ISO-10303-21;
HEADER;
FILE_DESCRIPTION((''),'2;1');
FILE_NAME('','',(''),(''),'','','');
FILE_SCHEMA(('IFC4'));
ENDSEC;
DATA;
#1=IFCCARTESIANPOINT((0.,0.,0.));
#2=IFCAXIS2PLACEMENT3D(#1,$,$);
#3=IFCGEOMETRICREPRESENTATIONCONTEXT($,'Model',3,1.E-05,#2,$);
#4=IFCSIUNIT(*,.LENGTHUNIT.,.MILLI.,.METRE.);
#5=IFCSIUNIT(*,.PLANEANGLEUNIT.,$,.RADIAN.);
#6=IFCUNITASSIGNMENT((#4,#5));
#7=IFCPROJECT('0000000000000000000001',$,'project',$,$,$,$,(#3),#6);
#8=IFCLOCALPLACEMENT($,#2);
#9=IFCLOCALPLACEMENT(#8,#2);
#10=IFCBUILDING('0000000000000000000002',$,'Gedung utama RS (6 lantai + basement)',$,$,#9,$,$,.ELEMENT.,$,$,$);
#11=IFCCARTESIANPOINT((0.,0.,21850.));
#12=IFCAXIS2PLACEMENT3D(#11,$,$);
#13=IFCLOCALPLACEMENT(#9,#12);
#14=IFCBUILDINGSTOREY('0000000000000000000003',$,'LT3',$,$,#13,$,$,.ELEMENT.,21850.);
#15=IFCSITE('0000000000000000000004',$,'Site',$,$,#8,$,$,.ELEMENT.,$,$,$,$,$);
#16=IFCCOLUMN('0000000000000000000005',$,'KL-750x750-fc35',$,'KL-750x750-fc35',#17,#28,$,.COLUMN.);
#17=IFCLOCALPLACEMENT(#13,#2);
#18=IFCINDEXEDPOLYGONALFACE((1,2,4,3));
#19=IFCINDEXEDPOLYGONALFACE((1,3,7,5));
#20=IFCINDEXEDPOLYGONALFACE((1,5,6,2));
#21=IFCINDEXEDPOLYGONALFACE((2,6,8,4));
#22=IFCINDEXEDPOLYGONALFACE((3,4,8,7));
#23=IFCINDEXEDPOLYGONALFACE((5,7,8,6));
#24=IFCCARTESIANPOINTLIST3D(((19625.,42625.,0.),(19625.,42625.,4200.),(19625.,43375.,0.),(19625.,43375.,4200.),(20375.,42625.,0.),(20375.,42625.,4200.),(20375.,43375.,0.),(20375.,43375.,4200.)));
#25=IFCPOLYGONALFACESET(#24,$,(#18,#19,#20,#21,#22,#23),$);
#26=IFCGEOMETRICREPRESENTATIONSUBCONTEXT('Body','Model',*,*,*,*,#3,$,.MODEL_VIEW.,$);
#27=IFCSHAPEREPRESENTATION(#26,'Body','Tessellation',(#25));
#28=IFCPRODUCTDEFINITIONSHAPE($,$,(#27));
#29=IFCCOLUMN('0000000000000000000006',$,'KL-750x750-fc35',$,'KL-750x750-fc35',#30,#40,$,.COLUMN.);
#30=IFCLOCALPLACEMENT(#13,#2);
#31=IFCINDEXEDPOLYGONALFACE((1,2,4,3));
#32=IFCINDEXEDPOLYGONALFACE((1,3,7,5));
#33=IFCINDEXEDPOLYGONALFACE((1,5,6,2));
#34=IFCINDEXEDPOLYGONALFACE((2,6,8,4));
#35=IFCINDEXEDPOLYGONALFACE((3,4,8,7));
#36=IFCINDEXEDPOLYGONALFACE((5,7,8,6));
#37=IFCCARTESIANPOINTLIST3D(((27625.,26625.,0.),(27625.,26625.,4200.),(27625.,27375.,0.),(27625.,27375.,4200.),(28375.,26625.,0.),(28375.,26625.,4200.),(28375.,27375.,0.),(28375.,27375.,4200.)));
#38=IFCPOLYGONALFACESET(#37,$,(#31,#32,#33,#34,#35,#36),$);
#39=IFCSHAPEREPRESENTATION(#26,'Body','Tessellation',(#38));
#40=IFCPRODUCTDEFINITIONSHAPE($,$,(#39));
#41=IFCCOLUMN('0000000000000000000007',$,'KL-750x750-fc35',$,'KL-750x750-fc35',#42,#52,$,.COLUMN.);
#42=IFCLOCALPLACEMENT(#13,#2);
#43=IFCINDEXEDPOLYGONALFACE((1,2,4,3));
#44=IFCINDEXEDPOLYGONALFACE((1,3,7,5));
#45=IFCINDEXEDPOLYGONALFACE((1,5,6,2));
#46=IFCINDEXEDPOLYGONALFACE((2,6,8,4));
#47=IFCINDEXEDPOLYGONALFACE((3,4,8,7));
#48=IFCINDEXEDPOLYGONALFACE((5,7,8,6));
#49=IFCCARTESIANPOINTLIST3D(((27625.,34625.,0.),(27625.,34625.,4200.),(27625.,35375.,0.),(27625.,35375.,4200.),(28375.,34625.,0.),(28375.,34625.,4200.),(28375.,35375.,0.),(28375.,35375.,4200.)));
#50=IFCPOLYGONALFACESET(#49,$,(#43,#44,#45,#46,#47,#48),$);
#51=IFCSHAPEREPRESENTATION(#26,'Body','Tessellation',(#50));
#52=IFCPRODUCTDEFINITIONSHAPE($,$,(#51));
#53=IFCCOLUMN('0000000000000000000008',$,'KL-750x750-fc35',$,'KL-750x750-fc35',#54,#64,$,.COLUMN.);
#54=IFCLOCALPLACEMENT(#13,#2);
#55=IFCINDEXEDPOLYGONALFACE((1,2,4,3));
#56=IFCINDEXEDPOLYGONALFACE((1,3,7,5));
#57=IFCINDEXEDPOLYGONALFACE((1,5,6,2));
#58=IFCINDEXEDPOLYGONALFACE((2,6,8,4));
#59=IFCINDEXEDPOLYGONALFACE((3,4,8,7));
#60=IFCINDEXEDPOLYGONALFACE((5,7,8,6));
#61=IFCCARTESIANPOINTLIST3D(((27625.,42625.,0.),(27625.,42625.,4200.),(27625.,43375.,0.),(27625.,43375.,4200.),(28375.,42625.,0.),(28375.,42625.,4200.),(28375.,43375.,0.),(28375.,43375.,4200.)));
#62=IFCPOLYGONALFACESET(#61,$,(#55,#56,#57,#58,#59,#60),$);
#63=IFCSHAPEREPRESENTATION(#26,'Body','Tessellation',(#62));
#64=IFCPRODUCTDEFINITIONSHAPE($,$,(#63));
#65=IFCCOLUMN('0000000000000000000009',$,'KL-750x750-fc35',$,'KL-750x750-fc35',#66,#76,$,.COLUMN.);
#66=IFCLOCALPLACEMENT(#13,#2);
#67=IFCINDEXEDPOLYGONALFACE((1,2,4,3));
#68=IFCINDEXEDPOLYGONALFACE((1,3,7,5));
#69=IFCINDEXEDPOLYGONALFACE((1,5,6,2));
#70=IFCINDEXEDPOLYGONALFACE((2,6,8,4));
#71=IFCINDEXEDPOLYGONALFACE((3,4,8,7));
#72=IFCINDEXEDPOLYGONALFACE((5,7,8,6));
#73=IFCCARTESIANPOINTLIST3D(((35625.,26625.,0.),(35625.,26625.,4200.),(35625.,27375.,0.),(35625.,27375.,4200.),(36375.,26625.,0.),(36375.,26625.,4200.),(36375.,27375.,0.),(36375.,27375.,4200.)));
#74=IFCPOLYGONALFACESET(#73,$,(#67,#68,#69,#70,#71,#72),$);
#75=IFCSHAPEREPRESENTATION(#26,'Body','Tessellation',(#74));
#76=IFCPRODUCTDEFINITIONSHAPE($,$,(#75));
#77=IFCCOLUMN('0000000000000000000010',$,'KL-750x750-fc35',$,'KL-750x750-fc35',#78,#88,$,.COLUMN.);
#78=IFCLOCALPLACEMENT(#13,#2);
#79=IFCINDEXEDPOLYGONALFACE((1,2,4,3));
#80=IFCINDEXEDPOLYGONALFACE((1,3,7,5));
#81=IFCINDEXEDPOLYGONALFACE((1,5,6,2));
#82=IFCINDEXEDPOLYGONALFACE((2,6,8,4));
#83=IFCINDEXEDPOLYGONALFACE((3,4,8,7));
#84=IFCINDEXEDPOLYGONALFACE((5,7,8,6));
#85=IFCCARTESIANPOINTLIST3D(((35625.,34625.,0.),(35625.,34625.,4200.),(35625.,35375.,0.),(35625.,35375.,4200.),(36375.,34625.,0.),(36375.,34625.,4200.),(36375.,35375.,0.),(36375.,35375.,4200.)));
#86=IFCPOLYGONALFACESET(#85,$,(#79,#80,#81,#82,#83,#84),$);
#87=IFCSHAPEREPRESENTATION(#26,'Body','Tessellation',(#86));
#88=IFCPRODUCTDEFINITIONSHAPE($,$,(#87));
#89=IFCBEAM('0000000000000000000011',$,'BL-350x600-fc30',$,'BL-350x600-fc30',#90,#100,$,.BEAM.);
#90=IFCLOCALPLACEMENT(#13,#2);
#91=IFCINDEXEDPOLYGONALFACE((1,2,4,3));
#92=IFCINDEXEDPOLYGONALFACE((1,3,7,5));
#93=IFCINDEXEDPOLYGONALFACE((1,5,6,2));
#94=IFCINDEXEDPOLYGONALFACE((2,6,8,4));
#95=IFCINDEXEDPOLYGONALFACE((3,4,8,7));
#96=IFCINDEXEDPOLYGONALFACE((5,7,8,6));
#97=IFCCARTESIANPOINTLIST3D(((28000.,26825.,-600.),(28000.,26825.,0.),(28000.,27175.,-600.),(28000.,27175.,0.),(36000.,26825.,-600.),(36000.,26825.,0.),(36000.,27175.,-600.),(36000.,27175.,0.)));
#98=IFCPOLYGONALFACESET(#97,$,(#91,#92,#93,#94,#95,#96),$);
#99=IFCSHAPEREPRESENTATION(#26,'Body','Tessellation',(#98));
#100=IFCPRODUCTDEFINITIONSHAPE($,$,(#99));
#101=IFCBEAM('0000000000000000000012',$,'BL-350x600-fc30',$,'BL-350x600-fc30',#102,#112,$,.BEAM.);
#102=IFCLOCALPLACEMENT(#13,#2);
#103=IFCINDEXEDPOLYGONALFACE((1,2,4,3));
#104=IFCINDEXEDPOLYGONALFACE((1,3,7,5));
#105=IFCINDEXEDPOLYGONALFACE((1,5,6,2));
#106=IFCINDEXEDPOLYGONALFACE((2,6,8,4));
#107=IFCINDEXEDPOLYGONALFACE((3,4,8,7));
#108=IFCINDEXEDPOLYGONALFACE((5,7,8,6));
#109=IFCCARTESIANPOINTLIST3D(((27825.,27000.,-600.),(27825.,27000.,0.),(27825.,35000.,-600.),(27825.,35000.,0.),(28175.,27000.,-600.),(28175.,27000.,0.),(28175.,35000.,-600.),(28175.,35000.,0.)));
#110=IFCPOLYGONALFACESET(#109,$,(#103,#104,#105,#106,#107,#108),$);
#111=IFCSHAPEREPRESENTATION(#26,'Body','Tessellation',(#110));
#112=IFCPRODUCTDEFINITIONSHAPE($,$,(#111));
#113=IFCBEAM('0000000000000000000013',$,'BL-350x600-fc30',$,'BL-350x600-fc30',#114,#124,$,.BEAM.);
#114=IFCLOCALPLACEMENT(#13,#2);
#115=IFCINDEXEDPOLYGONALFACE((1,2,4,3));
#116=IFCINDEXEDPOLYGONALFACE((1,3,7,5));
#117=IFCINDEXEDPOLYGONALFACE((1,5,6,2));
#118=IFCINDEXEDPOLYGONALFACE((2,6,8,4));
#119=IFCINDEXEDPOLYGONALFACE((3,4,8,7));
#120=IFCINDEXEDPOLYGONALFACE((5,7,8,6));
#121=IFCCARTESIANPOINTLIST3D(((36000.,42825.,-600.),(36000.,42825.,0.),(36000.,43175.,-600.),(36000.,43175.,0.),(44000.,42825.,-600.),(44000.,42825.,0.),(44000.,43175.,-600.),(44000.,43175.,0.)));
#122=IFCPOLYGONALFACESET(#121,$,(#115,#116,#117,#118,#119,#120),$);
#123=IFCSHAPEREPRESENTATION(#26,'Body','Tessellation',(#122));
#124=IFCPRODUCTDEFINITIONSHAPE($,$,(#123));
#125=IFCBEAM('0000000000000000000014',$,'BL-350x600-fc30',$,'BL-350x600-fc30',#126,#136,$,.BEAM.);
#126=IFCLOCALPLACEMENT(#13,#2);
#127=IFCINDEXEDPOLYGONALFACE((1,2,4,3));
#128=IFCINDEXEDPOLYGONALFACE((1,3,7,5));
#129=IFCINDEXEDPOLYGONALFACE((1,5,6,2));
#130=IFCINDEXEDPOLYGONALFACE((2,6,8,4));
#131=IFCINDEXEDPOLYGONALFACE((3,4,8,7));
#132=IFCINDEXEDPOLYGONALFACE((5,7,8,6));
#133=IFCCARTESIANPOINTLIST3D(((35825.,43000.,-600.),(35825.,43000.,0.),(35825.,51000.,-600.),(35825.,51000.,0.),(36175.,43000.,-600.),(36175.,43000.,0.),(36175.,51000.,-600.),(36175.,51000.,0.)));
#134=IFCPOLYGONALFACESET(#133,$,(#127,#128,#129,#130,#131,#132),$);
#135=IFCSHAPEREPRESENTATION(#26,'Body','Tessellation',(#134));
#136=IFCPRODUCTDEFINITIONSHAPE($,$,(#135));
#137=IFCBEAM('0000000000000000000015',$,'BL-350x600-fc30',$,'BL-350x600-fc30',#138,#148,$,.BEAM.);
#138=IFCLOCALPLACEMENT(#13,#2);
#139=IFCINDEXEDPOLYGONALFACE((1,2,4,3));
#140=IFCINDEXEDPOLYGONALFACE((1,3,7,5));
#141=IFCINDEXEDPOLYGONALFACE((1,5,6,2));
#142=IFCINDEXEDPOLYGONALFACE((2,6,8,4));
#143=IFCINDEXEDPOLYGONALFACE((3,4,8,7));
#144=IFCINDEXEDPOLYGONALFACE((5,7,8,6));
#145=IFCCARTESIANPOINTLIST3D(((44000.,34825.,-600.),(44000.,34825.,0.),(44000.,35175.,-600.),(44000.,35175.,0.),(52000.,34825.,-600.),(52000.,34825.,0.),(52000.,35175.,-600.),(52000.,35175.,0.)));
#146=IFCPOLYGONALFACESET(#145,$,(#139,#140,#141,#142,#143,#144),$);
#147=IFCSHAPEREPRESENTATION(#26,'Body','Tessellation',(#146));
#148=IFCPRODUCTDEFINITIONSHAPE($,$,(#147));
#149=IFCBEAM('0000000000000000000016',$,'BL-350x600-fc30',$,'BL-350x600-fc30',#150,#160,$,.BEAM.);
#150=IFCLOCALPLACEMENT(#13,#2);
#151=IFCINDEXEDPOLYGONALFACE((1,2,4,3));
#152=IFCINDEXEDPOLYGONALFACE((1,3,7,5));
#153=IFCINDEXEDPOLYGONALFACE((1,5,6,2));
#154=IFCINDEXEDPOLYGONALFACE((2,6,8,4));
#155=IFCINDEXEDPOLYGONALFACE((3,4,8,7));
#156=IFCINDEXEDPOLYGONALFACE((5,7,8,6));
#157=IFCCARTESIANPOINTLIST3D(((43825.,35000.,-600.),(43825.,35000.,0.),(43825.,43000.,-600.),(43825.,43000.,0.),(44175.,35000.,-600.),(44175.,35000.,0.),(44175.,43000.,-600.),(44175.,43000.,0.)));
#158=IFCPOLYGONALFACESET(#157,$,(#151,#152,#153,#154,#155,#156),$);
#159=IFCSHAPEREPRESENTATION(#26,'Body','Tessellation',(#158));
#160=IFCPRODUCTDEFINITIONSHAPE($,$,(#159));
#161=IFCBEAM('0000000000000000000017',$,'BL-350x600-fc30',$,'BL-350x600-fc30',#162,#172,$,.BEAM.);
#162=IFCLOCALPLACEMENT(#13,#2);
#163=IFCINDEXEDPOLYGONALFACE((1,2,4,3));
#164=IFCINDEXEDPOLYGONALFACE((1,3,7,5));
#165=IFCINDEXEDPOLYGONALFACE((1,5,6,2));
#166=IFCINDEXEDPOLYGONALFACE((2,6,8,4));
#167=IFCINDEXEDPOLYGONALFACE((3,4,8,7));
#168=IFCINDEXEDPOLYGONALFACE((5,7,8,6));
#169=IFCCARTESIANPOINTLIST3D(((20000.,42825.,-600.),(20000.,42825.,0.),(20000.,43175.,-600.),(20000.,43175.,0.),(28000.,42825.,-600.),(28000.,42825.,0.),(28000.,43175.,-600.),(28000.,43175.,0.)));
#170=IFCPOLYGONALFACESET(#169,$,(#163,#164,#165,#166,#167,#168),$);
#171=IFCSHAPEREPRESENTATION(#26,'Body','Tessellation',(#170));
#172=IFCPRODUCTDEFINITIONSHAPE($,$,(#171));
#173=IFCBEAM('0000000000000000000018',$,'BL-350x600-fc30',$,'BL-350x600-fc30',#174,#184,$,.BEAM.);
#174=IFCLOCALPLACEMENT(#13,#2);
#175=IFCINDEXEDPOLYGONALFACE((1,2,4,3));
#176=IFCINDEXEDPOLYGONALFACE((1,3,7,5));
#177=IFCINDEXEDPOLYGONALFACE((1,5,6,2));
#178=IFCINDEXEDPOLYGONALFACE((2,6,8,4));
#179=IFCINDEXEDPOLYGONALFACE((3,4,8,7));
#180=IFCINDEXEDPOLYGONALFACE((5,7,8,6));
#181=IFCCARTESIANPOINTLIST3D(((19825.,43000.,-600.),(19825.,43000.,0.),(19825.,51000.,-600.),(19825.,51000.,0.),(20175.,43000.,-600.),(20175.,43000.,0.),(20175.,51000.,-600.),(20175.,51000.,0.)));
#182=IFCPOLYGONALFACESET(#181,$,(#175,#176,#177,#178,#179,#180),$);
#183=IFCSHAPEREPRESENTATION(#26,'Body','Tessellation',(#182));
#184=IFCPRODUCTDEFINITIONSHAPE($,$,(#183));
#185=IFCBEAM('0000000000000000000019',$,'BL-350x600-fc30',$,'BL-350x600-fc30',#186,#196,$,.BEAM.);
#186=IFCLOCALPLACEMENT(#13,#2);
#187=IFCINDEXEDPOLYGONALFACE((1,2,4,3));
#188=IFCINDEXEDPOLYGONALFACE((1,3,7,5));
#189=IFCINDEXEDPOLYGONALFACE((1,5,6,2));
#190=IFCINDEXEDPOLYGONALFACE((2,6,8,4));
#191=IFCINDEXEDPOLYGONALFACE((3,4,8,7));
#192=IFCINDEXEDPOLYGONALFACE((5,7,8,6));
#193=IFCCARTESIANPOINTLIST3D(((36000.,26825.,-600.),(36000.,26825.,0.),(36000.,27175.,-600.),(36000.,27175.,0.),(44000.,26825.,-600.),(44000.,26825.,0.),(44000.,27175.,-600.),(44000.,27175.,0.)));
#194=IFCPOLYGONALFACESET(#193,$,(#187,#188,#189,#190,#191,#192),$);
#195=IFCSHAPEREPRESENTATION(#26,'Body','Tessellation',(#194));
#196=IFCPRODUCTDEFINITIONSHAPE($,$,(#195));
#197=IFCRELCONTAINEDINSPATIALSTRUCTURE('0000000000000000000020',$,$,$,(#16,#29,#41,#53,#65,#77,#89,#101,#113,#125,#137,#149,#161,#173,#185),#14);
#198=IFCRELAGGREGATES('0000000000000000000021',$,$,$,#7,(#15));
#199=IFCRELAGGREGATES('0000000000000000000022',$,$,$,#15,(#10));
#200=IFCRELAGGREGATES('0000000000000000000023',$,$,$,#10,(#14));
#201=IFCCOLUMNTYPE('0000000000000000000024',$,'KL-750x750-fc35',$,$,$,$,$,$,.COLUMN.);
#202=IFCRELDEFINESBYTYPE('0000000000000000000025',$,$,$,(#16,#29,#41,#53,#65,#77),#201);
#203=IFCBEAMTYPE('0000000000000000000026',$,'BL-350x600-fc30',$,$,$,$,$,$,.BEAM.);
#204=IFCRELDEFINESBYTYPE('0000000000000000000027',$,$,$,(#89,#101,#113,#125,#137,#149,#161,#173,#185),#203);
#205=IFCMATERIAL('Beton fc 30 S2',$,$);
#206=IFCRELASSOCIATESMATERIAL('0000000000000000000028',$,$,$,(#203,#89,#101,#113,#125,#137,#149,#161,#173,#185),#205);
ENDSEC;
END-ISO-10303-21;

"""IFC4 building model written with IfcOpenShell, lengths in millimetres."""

from ifc_helpers import new_model, si_unit, frame, origin, origin_2d, place, context, subcontext, project, spatial, rectangle, extrude, material, material_profile, profile_set, profile_usage, type_object, element, save


model = new_model("IFC4")

# Units and contexts
model_context = context("Model", 3, precision=1e-05, world=origin())
body_context = subcontext(model_context, "Body", "Model", "MODEL_VIEW")
ifc_project = project(units=[si_unit("LENGTHUNIT", "METRE", prefix="MILLI"), si_unit("PLANEANGLEUNIT", "RADIAN")], contexts=[model_context])

# Site, building, storey
site_placement = place(None, origin())
site = spatial("IfcSite", under=ifc_project, at=site_placement, Name="Site", CompositionType="ELEMENT")
building_placement = place(site_placement, origin())
building = spatial("IfcBuilding", under=site, at=building_placement, Name="Gedung utama RS (6 lantai + basement)", CompositionType="ELEMENT")
storey_placement = place(building_placement, frame((0.0, 0.0, 21850.0)))
storey = spatial("IfcBuildingStorey", under=building, at=storey_placement, Name="LT3", CompositionType="ELEMENT", Elevation=21850.0)

# Columns
ifc_material_profile_1 = material_profile(None, rectangle(XDim=750.0, YDim=750.0, at=origin_2d()), Name="KL-750x750-fc35")
ifc_profile_set_1 = profile_set([ifc_material_profile_1], Name="KL-750x750-fc35")
ifc_profile_usage_1 = profile_usage(ifc_profile_set_1, cardinal=5)
column_type = type_object("IfcColumnType", Name="KL-750x750-fc35", PredefinedType="COLUMN", material=ifc_profile_set_1)
for number, where, z_axis, x_axis, name in (
    (1, (20000.0, 43000.0, 0.0), (0.0, 0.0, 1.0), (1.0, 0.0, 0.0), "KL-750x750-fc35"),
    (2, (28000.0, 27000.0, 0.0), (0.0, 0.0, 1.0), (1.0, 0.0, 0.0), "KL-750x750-fc35"),
    (3, (28000.0, 35000.0, 0.0), (0.0, 0.0, 1.0), (1.0, 0.0, 0.0), "KL-750x750-fc35"),
    (4, (28000.0, 43000.0, 0.0), (0.0, 0.0, 1.0), (1.0, 0.0, 0.0), "KL-750x750-fc35"),
    (5, (36000.0, 27000.0, 0.0), (0.0, 0.0, 1.0), (1.0, 0.0, 0.0), "KL-750x750-fc35"),
    (6, (36000.0, 35000.0, 0.0), (0.0, 0.0, 1.0), (1.0, 0.0, 0.0), "KL-750x750-fc35"),
):
    element("IfcColumn", number, at=place(storey_placement, frame(where, z_axis=z_axis, x_axis=x_axis)), inside=storey, type_object=column_type, material=ifc_profile_usage_1, Name=name, ObjectType="KL-750x750-fc35", PredefinedType="COLUMN", context=body_context, shape_type="SweptSolid", body=[
        extrude(rectangle(XDim=750.0, YDim=750.0, at=origin_2d()), origin(), (0.0, 0.0, 1.0), 4200.0),
    ])

# Beams
ifc_material_1 = material(Name="Beton fc 30 S2")
ifc_material_profile_2 = material_profile(ifc_material_1, rectangle(XDim=350.0, YDim=600.0, at=origin_2d()), Name="BL-350x600-fc30")
ifc_profile_set_2 = profile_set([ifc_material_profile_2], Name="BL-350x600-fc30")
ifc_profile_usage_2 = profile_usage(ifc_profile_set_2, cardinal=8)
beam_type = type_object("IfcBeamType", Name="BL-350x600-fc30", PredefinedType="BEAM", material=ifc_profile_set_2)
beam_1_placement = place(storey_placement, frame((28000.0, 27000.0, -300.0)))
element("IfcBeam", 7, at=beam_1_placement, inside=storey, type_object=beam_type, material=ifc_profile_usage_2, Name="BL-350x600-fc30", ObjectType="BL-350x600-fc30", PredefinedType="BEAM", context=body_context, shape_type="SweptSolid", body=[
    extrude(rectangle(XDim=350.0, YDim=600.0, at=origin_2d()), frame((0.0, 0.0, 0.0), z_axis=(1.0, 0.0, 0.0), x_axis=(0.0, 1.0, 0.0)), (0.0, 0.0, 1.0), 8000.0),
])
beam_2_placement = place(storey_placement, frame((28000.0, 27000.0, -300.0)))
element("IfcBeam", 8, at=beam_2_placement, inside=storey, type_object=beam_type, material=ifc_profile_usage_2, Name="BL-350x600-fc30", ObjectType="BL-350x600-fc30", PredefinedType="BEAM", context=body_context, shape_type="SweptSolid", body=[
    extrude(rectangle(XDim=350.0, YDim=600.0, at=origin_2d()), frame((0.0, 0.0, 0.0), z_axis=(0.0, 1.0, 0.0), x_axis=(-1.0, 0.0, 0.0)), (0.0, 0.0, 1.0), 8000.0),
])
beam_3_placement = place(storey_placement, frame((36000.0, 43000.0, -300.0)))
element("IfcBeam", 9, at=beam_3_placement, inside=storey, type_object=beam_type, material=ifc_profile_usage_2, Name="BL-350x600-fc30", ObjectType="BL-350x600-fc30", PredefinedType="BEAM", context=body_context, shape_type="SweptSolid", body=[
    extrude(rectangle(XDim=350.0, YDim=600.0, at=origin_2d()), frame((0.0, 0.0, 0.0), z_axis=(1.0, 0.0, 0.0), x_axis=(0.0, 1.0, 0.0)), (0.0, 0.0, 1.0), 8000.0),
])
beam_4_placement = place(storey_placement, frame((36000.0, 43000.0, -300.0)))
element("IfcBeam", 10, at=beam_4_placement, inside=storey, type_object=beam_type, material=ifc_profile_usage_2, Name="BL-350x600-fc30", ObjectType="BL-350x600-fc30", PredefinedType="BEAM", context=body_context, shape_type="SweptSolid", body=[
    extrude(rectangle(XDim=350.0, YDim=600.0, at=origin_2d()), frame((0.0, 0.0, 0.0), z_axis=(0.0, 1.0, 0.0), x_axis=(-1.0, 0.0, 0.0)), (0.0, 0.0, 1.0), 8000.0),
])
beam_5_placement = place(storey_placement, frame((44000.0, 35000.0, -300.0)))
element("IfcBeam", 11, at=beam_5_placement, inside=storey, type_object=beam_type, material=ifc_profile_usage_2, Name="BL-350x600-fc30", ObjectType="BL-350x600-fc30", PredefinedType="BEAM", context=body_context, shape_type="SweptSolid", body=[
    extrude(rectangle(XDim=350.0, YDim=600.0, at=origin_2d()), frame((0.0, 0.0, 0.0), z_axis=(1.0, 0.0, 0.0), x_axis=(0.0, 1.0, 0.0)), (0.0, 0.0, 1.0), 8000.0),
])
beam_6_placement = place(storey_placement, frame((44000.0, 35000.0, -300.0)))
element("IfcBeam", 12, at=beam_6_placement, inside=storey, type_object=beam_type, material=ifc_profile_usage_2, Name="BL-350x600-fc30", ObjectType="BL-350x600-fc30", PredefinedType="BEAM", context=body_context, shape_type="SweptSolid", body=[
    extrude(rectangle(XDim=350.0, YDim=600.0, at=origin_2d()), frame((0.0, 0.0, 0.0), z_axis=(0.0, 1.0, 0.0), x_axis=(-1.0, 0.0, 0.0)), (0.0, 0.0, 1.0), 8000.0),
])
beam_7_placement = place(storey_placement, frame((20000.0, 43000.0, -300.0)))
element("IfcBeam", 13, at=beam_7_placement, inside=storey, type_object=beam_type, material=ifc_profile_usage_2, Name="BL-350x600-fc30", ObjectType="BL-350x600-fc30", PredefinedType="BEAM", context=body_context, shape_type="SweptSolid", body=[
    extrude(rectangle(XDim=350.0, YDim=600.0, at=origin_2d()), frame((0.0, 0.0, 0.0), z_axis=(1.0, 0.0, 0.0), x_axis=(0.0, 1.0, 0.0)), (0.0, 0.0, 1.0), 8000.0),
])
beam_8_placement = place(storey_placement, frame((20000.0, 43000.0, -300.0)))
element("IfcBeam", 14, at=beam_8_placement, inside=storey, type_object=beam_type, material=ifc_profile_usage_2, Name="BL-350x600-fc30", ObjectType="BL-350x600-fc30", PredefinedType="BEAM", context=body_context, shape_type="SweptSolid", body=[
    extrude(rectangle(XDim=350.0, YDim=600.0, at=origin_2d()), frame((0.0, 0.0, 0.0), z_axis=(0.0, 1.0, 0.0), x_axis=(-1.0, 0.0, 0.0)), (0.0, 0.0, 1.0), 8000.0),
])
beam_9_placement = place(storey_placement, frame((36000.0, 27000.0, -300.0)))
element("IfcBeam", 15, at=beam_9_placement, inside=storey, type_object=beam_type, material=ifc_profile_usage_2, Name="BL-350x600-fc30", ObjectType="BL-350x600-fc30", PredefinedType="BEAM", context=body_context, shape_type="SweptSolid", body=[
    extrude(rectangle(XDim=350.0, YDim=600.0, at=origin_2d()), frame((0.0, 0.0, 0.0), z_axis=(1.0, 0.0, 0.0), x_axis=(0.0, 1.0, 0.0)), (0.0, 0.0, 1.0), 8000.0),
])

save(model, "model.ifc")
